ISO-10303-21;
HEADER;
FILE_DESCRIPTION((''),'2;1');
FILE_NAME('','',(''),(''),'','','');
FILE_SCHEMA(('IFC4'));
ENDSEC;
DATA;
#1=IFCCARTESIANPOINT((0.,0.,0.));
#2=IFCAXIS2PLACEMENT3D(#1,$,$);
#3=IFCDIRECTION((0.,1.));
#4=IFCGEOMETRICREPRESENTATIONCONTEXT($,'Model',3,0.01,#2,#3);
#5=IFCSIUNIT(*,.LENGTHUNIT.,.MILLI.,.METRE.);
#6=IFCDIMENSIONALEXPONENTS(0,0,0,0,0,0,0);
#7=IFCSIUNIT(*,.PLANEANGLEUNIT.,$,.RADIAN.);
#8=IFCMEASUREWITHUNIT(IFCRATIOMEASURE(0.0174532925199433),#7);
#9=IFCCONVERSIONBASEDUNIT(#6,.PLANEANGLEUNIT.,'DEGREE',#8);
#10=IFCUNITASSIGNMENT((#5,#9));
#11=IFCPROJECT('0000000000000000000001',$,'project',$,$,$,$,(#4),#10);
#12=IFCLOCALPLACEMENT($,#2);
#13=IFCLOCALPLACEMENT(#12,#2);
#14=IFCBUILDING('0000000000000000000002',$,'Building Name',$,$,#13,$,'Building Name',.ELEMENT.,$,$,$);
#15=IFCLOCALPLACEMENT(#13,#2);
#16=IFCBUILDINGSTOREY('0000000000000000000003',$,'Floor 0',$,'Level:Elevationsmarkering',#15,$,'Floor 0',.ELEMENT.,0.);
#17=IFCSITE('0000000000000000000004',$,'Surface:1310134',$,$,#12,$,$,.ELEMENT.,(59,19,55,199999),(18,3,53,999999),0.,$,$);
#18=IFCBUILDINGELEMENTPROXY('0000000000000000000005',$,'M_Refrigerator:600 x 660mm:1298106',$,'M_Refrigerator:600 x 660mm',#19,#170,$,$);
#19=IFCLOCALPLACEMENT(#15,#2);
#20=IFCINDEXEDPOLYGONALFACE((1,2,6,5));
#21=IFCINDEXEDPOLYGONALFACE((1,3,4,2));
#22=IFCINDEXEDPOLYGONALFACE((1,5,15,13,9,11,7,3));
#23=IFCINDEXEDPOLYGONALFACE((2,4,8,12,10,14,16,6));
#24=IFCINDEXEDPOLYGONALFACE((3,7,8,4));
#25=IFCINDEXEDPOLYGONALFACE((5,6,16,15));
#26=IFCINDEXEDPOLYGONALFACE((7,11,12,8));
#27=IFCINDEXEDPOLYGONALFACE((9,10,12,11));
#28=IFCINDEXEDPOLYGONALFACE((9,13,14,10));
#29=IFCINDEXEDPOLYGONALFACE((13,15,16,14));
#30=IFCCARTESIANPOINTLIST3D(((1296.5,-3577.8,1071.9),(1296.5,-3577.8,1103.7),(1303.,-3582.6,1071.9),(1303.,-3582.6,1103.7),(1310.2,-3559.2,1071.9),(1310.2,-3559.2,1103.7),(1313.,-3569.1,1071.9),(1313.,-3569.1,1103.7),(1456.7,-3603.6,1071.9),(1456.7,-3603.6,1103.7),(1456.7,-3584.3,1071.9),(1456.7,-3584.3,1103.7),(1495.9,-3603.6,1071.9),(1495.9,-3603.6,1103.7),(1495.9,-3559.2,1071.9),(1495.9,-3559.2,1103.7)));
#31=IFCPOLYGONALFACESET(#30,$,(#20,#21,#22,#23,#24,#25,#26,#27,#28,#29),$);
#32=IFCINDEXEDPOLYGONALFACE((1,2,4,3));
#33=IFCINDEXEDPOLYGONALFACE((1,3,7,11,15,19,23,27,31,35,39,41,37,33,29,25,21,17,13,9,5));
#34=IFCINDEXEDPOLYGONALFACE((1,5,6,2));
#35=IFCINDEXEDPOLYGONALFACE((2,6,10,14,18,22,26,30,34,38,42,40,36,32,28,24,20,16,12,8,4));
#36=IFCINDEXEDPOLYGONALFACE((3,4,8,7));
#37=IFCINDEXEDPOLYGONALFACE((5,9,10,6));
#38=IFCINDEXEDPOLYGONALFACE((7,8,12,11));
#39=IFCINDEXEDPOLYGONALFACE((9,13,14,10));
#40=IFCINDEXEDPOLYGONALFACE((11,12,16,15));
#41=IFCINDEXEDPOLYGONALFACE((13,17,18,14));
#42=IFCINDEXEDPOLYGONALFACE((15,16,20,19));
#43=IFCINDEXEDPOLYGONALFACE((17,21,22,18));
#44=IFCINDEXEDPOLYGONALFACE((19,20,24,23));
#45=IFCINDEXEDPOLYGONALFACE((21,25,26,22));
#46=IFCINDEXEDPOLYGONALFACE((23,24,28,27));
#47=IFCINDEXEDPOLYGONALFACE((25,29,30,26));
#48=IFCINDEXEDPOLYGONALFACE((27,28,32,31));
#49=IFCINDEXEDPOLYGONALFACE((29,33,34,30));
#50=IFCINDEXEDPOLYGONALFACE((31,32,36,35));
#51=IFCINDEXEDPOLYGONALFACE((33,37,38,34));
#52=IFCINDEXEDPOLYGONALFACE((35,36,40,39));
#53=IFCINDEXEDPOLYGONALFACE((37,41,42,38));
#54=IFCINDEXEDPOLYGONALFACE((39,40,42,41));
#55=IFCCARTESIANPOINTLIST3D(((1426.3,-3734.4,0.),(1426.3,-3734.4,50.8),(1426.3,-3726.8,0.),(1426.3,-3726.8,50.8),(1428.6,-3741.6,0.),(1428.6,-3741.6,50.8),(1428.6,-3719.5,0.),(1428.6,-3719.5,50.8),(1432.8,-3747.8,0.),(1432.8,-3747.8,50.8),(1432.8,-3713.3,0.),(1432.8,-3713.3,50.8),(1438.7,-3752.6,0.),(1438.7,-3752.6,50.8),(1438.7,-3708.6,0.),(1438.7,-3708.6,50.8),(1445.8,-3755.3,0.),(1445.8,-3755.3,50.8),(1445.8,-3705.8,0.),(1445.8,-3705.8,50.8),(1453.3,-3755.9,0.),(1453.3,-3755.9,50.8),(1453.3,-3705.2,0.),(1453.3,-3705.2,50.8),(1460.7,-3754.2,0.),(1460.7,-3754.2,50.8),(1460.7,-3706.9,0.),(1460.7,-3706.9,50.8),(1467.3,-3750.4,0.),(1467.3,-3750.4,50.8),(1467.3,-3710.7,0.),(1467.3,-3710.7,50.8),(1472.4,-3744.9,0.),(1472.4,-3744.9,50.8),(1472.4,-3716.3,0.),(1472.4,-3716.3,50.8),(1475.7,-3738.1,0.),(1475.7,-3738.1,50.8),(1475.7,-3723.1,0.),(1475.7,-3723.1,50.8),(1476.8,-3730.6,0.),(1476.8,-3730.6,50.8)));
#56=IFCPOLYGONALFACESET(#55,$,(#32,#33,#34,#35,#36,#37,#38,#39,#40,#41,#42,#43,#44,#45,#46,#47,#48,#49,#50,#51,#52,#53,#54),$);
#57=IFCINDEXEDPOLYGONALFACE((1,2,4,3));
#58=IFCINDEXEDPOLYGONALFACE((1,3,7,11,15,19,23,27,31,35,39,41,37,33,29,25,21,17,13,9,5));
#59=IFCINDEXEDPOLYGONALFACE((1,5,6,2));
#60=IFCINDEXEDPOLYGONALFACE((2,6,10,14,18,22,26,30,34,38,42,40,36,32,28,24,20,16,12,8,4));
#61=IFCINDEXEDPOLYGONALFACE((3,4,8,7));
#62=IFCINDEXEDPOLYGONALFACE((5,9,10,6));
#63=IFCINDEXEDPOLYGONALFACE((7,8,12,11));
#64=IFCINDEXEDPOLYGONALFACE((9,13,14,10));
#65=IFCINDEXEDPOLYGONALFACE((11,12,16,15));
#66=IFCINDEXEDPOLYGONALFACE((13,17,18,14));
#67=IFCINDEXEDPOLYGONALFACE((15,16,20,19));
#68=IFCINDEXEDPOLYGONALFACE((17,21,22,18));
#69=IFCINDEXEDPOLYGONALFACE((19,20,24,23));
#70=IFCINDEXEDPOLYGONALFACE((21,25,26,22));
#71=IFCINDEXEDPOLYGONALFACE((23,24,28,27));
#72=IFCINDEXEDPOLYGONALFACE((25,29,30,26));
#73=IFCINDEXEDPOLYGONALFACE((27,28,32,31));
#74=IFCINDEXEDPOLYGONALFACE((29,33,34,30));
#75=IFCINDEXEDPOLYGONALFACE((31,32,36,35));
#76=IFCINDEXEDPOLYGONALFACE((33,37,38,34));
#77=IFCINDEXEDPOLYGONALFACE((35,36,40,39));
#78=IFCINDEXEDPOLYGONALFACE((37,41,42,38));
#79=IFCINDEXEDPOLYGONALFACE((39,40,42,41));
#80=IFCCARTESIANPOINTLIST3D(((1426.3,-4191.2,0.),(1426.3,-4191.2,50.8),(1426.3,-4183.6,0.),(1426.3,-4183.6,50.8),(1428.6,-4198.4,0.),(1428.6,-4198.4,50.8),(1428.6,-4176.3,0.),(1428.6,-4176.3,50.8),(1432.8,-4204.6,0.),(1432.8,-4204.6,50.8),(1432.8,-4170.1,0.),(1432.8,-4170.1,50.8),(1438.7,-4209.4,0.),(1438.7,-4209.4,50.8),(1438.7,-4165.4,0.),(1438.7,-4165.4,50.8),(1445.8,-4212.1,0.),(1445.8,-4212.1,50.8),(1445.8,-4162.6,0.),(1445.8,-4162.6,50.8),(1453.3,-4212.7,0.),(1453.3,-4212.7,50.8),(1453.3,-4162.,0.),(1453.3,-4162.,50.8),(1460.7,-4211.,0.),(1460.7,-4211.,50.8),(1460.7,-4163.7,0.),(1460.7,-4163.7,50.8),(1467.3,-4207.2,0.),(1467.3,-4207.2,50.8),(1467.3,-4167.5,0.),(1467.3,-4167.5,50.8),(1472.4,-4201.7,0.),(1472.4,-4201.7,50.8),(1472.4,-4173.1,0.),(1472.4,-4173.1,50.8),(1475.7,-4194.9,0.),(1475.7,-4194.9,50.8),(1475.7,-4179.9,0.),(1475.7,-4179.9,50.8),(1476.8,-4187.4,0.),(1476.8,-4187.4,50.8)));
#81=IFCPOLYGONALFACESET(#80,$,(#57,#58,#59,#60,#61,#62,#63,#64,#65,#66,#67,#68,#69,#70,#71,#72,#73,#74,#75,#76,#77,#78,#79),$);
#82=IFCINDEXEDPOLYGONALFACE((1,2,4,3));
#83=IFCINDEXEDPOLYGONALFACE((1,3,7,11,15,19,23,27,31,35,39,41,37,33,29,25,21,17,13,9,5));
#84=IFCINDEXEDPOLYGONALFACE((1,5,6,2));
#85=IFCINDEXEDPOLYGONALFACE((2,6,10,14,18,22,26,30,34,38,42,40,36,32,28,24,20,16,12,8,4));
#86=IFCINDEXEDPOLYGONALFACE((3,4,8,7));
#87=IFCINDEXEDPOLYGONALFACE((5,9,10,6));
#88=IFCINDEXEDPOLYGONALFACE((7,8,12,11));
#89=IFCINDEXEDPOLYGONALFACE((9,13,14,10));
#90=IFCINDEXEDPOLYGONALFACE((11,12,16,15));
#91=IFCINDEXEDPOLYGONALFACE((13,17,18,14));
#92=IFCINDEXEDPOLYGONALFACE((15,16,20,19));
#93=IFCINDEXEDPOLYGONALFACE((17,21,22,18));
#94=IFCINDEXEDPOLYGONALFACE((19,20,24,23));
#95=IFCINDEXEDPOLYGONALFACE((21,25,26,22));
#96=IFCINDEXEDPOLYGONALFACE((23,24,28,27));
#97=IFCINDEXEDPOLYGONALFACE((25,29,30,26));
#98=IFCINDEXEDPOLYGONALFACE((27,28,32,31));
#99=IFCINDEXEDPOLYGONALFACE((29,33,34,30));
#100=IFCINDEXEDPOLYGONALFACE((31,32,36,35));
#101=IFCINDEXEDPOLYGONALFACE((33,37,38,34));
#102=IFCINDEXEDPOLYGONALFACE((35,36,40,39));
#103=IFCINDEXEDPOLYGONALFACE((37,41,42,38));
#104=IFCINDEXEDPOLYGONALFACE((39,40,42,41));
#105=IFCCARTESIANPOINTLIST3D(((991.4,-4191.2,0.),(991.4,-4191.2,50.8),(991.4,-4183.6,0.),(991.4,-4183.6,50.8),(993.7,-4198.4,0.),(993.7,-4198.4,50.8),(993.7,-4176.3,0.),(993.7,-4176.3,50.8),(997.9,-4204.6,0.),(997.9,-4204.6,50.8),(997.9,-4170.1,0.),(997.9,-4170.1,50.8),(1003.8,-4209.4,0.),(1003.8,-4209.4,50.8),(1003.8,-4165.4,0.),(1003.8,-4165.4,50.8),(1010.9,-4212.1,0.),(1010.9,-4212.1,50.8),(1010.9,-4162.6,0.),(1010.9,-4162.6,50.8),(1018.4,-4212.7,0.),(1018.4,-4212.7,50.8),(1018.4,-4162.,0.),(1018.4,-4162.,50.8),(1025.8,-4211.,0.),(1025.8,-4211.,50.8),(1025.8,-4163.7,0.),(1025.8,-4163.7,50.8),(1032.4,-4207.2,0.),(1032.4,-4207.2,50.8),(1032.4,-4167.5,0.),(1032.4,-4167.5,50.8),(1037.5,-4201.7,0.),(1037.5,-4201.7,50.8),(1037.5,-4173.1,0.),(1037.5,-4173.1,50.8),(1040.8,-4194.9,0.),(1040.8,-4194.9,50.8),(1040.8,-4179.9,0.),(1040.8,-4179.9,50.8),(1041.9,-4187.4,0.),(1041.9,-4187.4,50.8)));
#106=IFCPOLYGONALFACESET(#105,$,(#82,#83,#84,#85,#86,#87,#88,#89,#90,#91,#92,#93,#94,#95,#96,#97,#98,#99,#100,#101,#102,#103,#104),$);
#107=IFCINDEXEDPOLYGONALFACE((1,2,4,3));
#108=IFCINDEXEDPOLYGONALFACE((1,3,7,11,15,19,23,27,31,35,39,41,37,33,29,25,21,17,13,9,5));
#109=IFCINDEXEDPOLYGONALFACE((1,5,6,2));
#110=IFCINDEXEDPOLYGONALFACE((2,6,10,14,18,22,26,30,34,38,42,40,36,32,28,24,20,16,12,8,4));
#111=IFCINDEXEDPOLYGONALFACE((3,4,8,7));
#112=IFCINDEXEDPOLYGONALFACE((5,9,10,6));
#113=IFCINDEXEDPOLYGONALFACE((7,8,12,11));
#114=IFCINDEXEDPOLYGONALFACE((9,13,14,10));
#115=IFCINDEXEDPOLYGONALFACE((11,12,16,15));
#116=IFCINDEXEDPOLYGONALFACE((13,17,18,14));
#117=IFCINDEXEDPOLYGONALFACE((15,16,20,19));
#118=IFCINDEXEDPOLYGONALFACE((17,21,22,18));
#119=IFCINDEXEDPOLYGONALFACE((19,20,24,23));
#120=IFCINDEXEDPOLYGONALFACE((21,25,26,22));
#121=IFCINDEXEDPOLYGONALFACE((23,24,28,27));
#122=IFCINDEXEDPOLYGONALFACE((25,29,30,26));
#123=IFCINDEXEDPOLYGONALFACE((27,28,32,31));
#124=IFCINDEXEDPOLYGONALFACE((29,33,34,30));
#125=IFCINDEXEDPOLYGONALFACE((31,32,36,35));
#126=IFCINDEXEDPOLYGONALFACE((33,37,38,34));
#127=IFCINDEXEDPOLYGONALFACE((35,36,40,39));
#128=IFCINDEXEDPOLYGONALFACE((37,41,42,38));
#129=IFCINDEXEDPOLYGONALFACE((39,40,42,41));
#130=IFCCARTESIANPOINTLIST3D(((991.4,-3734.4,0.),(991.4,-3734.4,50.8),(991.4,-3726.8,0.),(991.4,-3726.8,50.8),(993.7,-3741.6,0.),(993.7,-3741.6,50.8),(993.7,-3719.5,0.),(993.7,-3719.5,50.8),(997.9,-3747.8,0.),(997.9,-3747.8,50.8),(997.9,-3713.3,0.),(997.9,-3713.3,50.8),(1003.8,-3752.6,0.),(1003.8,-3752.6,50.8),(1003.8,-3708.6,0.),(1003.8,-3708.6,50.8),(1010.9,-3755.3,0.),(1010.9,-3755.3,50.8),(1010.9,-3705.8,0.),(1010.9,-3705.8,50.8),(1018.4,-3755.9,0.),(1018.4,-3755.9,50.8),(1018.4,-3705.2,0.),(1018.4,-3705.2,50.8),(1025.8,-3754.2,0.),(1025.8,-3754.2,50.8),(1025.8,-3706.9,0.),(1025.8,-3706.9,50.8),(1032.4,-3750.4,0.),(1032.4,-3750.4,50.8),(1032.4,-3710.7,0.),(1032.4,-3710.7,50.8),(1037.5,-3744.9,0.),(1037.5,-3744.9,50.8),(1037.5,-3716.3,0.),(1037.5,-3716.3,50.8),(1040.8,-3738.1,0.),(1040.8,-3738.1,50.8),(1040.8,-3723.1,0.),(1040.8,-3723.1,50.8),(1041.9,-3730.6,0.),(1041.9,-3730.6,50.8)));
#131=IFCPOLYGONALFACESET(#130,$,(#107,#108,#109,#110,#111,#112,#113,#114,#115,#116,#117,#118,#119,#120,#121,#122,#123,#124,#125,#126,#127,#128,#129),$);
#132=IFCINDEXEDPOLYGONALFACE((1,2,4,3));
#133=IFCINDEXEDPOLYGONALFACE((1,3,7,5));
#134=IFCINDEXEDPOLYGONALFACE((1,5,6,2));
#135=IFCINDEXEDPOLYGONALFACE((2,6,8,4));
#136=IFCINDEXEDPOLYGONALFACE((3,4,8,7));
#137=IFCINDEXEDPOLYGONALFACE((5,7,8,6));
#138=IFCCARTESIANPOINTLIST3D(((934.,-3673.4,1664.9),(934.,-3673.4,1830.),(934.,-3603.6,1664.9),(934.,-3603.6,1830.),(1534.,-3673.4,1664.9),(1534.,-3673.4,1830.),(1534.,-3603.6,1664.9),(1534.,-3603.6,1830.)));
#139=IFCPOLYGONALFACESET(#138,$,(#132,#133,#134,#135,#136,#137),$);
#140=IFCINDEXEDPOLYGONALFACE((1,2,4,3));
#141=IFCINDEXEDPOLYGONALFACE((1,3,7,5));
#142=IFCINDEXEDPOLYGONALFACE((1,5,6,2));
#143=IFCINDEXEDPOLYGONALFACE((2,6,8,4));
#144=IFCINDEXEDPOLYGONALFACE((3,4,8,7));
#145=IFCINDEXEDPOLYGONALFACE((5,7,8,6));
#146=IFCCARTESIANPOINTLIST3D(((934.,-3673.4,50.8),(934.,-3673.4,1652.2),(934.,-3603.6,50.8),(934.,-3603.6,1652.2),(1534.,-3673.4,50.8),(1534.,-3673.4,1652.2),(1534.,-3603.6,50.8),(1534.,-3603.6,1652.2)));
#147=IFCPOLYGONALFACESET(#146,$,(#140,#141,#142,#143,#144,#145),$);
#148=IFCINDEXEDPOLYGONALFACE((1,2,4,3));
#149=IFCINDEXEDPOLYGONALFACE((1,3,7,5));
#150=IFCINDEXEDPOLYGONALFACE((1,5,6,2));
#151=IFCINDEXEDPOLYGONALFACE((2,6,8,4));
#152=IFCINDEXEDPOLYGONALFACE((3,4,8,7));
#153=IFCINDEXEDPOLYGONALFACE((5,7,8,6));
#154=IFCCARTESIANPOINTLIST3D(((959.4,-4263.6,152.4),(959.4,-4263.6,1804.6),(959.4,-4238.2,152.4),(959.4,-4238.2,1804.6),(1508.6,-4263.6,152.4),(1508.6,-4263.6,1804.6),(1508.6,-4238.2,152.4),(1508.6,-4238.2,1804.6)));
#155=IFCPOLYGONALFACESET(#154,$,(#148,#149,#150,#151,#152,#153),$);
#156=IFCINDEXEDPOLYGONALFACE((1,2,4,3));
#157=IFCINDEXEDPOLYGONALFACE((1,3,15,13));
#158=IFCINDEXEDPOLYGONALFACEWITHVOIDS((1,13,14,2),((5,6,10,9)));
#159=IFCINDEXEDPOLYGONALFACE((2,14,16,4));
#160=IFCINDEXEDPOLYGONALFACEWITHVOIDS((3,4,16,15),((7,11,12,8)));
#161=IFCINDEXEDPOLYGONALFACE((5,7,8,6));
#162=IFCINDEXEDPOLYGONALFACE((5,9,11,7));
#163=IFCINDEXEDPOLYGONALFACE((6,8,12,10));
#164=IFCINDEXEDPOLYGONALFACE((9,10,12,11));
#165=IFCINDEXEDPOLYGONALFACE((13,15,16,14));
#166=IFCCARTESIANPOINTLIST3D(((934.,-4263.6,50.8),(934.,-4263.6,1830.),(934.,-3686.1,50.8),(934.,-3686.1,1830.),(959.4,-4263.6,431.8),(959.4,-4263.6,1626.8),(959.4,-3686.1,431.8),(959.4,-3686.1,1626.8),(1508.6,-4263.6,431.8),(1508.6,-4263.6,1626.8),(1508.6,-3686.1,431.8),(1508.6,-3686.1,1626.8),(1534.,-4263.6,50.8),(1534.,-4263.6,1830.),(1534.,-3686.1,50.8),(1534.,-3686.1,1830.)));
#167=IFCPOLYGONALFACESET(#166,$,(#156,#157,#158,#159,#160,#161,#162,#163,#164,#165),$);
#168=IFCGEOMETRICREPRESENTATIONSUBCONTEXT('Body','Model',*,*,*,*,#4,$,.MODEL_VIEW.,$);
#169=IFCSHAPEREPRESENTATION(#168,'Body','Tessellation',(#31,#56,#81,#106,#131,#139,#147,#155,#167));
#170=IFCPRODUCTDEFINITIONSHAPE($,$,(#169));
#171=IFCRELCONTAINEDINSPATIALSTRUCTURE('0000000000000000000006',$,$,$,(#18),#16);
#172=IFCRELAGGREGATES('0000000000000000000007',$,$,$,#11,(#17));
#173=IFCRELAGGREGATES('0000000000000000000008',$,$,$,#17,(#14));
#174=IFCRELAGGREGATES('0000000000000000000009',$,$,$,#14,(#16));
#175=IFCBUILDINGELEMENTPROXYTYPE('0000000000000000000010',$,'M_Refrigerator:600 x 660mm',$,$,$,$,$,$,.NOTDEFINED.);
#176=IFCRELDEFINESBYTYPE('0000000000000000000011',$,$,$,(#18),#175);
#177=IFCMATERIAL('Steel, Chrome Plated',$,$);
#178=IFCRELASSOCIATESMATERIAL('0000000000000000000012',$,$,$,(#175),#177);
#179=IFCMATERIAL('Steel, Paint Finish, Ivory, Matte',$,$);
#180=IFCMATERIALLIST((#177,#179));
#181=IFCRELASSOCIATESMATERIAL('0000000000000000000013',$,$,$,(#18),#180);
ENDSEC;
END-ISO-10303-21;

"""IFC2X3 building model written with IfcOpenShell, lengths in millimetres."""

from ifc_helpers import new_model, entity, si_unit, converted_unit, direction, frame, frame_2d, origin, origin_2d_with_axis, place, context, subcontext, project, spatial, polyline, rectangle, circle, outline, extrude, source, transform, mapped, material, material_list, type_object, type_shapes, element, save


model = new_model("IFC2X3")

# Units and contexts
model_context = context("Model", 3, precision=0.01, world=origin(), true_north=direction((0.0, 1.0)))
body_context = subcontext(model_context, "Body", "Model", "MODEL_VIEW")
ifc_project = project(units=[si_unit("LENGTHUNIT", "METRE", prefix="MILLI"), converted_unit("PLANEANGLEUNIT", "DEGREE", entity("IfcRatioMeasure", 0.0174532925199433), si_unit("PLANEANGLEUNIT", "RADIAN"), dimensions=[0, 0, 0, 0, 0, 0, 0])], contexts=[model_context])

# Site, building, storey
site_placement = place(None, origin())
site = spatial("IfcSite", under=ifc_project, at=site_placement, Name="Surface:1310134", CompositionType="ELEMENT", RefLatitude=(59, 19, 55, 199999), RefLongitude=(18, 3, 53, 999999), RefElevation=0.0)
building_placement = place(site_placement, origin())
building = spatial("IfcBuilding", under=site, at=building_placement, Name="Building Name", LongName="Building Name", CompositionType="ELEMENT")
storey_placement = place(building_placement, origin())
storey = spatial("IfcBuildingStorey", under=building, at=storey_placement, Name="Floor 0", ObjectType="Level:Elevationsmarkering", LongName="Floor 0", CompositionType="ELEMENT", Elevation=0.0)

# Shared definitions
ifc_material_1 = material(Name="Steel, Chrome Plated")

# Building element proxy
ifc_material_2 = material(Name="Steel, Paint Finish, Ivory, Matte")
ifc_material_list_1 = material_list([ifc_material_1, ifc_material_2])
building_element_proxy_type_1 = type_object("IfcBuildingElementProxyType", Name="M_Refrigerator:600 x 660mm", PredefinedType="NOTDEFINED", material=ifc_material_1)
shared_shape_1 = source(origin(), body_context, "Body", "SweptSolid", [
    extrude(outline(polyline([(-104.9, -20.7), (80.8, -20.7), (94.5, -2.1), (88.0, 2.7), (78.0, -10.8), (-65.7, 4.4), (-65.7, 23.6), (-104.9, 23.6), (-104.9, -20.7)])), frame((103.2, 387.4, 1071.9), z_axis=(0.0, 0.0, 1.0), x_axis=(-1.0, 0.0, 0.0)), (0.0, 0.0, 1.0), 31.8),
    extrude(circle(Radius=25.4, at=frame_2d((0.0, 0.0), x_axis=(1.0, 0.0))), frame((163.6, 236.8, 0.0)), (0.0, 0.0, 1.0), 50.8),
    extrude(circle(Radius=25.4, at=origin_2d_with_axis()), frame((163.6, -220.0, 0.0)), (0.0, 0.0, 1.0), 50.8),
    extrude(circle(Radius=25.4, at=frame_2d((0.0, 0.0), x_axis=(1.0, 0.0))), frame((-271.3, -220.0, 0.0)), (0.0, 0.0, 1.0), 50.8),
    extrude(circle(Radius=25.4, at=frame_2d((0.0, 0.0), x_axis=(1.0, 0.0))), frame((-271.3, 236.8, 0.0)), (0.0, 0.0, 1.0), 50.8),
    extrude(rectangle(XDim=600.0, YDim=69.8, at=frame_2d((0.0, 0.0), x_axis=(1.0, 0.0))), frame((-53.8, 328.9, 1664.9), z_axis=(0.0, 0.0, 1.0), x_axis=(-1.0, 0.0, 0.0)), (0.0, 0.0, 1.0), 165.1),
    extrude(rectangle(XDim=600.0, YDim=69.8, at=frame_2d((0.0, 0.0), x_axis=(1.0, 0.0))), frame((-53.8, 328.9, 50.8), z_axis=(0.0, 0.0, 1.0), x_axis=(-1.0, 0.0, 0.0)), (0.0, 0.0, 1.0), 1601.4),
    extrude(rectangle(XDim=549.2, YDim=25.4, at=frame_2d((0.0, 0.0), x_axis=(1.0, 0.0))), frame((-53.8, -283.5, 152.4), z_axis=(0.0, 0.0, 1.0), x_axis=(-1.0, 0.0, 0.0)), (0.0, 0.0, 1.0), 1652.2),
    extrude(outline(polyline([(-889.6, -300.0), (889.6, -300.0), (889.6, 300.0), (-889.6, 300.0), (-889.6, -300.0)]), holes=[polyline([(-686.4, -274.6), (-686.4, 274.6), (508.6, 274.6), (508.6, -274.6), (-686.4, -274.6)])]), frame((-53.8, -296.2, 940.4), z_axis=(0.0, 1.0, 0.0), x_axis=(0.0, 0.0, -1.0)), (0.0, 0.0, 1.0), 577.5),
])
type_shapes(building_element_proxy_type_1, [shared_shape_1])
proxy_1_placement = place(storey_placement, frame((1287.8, -3967.4, 0.0)))
element("IfcBuildingElementProxy", 1, at=proxy_1_placement, inside=storey, type_object=building_element_proxy_type_1, material=ifc_material_list_1, Name="M_Refrigerator:600 x 660mm:1298106", ObjectType="M_Refrigerator:600 x 660mm", context=body_context, shape_type="MappedRepresentation", body=[
    mapped(shared_shape_1, transform((0.0, 0.0, 0.0), scale=1.0)),
])

save(model, "model.ifc")
